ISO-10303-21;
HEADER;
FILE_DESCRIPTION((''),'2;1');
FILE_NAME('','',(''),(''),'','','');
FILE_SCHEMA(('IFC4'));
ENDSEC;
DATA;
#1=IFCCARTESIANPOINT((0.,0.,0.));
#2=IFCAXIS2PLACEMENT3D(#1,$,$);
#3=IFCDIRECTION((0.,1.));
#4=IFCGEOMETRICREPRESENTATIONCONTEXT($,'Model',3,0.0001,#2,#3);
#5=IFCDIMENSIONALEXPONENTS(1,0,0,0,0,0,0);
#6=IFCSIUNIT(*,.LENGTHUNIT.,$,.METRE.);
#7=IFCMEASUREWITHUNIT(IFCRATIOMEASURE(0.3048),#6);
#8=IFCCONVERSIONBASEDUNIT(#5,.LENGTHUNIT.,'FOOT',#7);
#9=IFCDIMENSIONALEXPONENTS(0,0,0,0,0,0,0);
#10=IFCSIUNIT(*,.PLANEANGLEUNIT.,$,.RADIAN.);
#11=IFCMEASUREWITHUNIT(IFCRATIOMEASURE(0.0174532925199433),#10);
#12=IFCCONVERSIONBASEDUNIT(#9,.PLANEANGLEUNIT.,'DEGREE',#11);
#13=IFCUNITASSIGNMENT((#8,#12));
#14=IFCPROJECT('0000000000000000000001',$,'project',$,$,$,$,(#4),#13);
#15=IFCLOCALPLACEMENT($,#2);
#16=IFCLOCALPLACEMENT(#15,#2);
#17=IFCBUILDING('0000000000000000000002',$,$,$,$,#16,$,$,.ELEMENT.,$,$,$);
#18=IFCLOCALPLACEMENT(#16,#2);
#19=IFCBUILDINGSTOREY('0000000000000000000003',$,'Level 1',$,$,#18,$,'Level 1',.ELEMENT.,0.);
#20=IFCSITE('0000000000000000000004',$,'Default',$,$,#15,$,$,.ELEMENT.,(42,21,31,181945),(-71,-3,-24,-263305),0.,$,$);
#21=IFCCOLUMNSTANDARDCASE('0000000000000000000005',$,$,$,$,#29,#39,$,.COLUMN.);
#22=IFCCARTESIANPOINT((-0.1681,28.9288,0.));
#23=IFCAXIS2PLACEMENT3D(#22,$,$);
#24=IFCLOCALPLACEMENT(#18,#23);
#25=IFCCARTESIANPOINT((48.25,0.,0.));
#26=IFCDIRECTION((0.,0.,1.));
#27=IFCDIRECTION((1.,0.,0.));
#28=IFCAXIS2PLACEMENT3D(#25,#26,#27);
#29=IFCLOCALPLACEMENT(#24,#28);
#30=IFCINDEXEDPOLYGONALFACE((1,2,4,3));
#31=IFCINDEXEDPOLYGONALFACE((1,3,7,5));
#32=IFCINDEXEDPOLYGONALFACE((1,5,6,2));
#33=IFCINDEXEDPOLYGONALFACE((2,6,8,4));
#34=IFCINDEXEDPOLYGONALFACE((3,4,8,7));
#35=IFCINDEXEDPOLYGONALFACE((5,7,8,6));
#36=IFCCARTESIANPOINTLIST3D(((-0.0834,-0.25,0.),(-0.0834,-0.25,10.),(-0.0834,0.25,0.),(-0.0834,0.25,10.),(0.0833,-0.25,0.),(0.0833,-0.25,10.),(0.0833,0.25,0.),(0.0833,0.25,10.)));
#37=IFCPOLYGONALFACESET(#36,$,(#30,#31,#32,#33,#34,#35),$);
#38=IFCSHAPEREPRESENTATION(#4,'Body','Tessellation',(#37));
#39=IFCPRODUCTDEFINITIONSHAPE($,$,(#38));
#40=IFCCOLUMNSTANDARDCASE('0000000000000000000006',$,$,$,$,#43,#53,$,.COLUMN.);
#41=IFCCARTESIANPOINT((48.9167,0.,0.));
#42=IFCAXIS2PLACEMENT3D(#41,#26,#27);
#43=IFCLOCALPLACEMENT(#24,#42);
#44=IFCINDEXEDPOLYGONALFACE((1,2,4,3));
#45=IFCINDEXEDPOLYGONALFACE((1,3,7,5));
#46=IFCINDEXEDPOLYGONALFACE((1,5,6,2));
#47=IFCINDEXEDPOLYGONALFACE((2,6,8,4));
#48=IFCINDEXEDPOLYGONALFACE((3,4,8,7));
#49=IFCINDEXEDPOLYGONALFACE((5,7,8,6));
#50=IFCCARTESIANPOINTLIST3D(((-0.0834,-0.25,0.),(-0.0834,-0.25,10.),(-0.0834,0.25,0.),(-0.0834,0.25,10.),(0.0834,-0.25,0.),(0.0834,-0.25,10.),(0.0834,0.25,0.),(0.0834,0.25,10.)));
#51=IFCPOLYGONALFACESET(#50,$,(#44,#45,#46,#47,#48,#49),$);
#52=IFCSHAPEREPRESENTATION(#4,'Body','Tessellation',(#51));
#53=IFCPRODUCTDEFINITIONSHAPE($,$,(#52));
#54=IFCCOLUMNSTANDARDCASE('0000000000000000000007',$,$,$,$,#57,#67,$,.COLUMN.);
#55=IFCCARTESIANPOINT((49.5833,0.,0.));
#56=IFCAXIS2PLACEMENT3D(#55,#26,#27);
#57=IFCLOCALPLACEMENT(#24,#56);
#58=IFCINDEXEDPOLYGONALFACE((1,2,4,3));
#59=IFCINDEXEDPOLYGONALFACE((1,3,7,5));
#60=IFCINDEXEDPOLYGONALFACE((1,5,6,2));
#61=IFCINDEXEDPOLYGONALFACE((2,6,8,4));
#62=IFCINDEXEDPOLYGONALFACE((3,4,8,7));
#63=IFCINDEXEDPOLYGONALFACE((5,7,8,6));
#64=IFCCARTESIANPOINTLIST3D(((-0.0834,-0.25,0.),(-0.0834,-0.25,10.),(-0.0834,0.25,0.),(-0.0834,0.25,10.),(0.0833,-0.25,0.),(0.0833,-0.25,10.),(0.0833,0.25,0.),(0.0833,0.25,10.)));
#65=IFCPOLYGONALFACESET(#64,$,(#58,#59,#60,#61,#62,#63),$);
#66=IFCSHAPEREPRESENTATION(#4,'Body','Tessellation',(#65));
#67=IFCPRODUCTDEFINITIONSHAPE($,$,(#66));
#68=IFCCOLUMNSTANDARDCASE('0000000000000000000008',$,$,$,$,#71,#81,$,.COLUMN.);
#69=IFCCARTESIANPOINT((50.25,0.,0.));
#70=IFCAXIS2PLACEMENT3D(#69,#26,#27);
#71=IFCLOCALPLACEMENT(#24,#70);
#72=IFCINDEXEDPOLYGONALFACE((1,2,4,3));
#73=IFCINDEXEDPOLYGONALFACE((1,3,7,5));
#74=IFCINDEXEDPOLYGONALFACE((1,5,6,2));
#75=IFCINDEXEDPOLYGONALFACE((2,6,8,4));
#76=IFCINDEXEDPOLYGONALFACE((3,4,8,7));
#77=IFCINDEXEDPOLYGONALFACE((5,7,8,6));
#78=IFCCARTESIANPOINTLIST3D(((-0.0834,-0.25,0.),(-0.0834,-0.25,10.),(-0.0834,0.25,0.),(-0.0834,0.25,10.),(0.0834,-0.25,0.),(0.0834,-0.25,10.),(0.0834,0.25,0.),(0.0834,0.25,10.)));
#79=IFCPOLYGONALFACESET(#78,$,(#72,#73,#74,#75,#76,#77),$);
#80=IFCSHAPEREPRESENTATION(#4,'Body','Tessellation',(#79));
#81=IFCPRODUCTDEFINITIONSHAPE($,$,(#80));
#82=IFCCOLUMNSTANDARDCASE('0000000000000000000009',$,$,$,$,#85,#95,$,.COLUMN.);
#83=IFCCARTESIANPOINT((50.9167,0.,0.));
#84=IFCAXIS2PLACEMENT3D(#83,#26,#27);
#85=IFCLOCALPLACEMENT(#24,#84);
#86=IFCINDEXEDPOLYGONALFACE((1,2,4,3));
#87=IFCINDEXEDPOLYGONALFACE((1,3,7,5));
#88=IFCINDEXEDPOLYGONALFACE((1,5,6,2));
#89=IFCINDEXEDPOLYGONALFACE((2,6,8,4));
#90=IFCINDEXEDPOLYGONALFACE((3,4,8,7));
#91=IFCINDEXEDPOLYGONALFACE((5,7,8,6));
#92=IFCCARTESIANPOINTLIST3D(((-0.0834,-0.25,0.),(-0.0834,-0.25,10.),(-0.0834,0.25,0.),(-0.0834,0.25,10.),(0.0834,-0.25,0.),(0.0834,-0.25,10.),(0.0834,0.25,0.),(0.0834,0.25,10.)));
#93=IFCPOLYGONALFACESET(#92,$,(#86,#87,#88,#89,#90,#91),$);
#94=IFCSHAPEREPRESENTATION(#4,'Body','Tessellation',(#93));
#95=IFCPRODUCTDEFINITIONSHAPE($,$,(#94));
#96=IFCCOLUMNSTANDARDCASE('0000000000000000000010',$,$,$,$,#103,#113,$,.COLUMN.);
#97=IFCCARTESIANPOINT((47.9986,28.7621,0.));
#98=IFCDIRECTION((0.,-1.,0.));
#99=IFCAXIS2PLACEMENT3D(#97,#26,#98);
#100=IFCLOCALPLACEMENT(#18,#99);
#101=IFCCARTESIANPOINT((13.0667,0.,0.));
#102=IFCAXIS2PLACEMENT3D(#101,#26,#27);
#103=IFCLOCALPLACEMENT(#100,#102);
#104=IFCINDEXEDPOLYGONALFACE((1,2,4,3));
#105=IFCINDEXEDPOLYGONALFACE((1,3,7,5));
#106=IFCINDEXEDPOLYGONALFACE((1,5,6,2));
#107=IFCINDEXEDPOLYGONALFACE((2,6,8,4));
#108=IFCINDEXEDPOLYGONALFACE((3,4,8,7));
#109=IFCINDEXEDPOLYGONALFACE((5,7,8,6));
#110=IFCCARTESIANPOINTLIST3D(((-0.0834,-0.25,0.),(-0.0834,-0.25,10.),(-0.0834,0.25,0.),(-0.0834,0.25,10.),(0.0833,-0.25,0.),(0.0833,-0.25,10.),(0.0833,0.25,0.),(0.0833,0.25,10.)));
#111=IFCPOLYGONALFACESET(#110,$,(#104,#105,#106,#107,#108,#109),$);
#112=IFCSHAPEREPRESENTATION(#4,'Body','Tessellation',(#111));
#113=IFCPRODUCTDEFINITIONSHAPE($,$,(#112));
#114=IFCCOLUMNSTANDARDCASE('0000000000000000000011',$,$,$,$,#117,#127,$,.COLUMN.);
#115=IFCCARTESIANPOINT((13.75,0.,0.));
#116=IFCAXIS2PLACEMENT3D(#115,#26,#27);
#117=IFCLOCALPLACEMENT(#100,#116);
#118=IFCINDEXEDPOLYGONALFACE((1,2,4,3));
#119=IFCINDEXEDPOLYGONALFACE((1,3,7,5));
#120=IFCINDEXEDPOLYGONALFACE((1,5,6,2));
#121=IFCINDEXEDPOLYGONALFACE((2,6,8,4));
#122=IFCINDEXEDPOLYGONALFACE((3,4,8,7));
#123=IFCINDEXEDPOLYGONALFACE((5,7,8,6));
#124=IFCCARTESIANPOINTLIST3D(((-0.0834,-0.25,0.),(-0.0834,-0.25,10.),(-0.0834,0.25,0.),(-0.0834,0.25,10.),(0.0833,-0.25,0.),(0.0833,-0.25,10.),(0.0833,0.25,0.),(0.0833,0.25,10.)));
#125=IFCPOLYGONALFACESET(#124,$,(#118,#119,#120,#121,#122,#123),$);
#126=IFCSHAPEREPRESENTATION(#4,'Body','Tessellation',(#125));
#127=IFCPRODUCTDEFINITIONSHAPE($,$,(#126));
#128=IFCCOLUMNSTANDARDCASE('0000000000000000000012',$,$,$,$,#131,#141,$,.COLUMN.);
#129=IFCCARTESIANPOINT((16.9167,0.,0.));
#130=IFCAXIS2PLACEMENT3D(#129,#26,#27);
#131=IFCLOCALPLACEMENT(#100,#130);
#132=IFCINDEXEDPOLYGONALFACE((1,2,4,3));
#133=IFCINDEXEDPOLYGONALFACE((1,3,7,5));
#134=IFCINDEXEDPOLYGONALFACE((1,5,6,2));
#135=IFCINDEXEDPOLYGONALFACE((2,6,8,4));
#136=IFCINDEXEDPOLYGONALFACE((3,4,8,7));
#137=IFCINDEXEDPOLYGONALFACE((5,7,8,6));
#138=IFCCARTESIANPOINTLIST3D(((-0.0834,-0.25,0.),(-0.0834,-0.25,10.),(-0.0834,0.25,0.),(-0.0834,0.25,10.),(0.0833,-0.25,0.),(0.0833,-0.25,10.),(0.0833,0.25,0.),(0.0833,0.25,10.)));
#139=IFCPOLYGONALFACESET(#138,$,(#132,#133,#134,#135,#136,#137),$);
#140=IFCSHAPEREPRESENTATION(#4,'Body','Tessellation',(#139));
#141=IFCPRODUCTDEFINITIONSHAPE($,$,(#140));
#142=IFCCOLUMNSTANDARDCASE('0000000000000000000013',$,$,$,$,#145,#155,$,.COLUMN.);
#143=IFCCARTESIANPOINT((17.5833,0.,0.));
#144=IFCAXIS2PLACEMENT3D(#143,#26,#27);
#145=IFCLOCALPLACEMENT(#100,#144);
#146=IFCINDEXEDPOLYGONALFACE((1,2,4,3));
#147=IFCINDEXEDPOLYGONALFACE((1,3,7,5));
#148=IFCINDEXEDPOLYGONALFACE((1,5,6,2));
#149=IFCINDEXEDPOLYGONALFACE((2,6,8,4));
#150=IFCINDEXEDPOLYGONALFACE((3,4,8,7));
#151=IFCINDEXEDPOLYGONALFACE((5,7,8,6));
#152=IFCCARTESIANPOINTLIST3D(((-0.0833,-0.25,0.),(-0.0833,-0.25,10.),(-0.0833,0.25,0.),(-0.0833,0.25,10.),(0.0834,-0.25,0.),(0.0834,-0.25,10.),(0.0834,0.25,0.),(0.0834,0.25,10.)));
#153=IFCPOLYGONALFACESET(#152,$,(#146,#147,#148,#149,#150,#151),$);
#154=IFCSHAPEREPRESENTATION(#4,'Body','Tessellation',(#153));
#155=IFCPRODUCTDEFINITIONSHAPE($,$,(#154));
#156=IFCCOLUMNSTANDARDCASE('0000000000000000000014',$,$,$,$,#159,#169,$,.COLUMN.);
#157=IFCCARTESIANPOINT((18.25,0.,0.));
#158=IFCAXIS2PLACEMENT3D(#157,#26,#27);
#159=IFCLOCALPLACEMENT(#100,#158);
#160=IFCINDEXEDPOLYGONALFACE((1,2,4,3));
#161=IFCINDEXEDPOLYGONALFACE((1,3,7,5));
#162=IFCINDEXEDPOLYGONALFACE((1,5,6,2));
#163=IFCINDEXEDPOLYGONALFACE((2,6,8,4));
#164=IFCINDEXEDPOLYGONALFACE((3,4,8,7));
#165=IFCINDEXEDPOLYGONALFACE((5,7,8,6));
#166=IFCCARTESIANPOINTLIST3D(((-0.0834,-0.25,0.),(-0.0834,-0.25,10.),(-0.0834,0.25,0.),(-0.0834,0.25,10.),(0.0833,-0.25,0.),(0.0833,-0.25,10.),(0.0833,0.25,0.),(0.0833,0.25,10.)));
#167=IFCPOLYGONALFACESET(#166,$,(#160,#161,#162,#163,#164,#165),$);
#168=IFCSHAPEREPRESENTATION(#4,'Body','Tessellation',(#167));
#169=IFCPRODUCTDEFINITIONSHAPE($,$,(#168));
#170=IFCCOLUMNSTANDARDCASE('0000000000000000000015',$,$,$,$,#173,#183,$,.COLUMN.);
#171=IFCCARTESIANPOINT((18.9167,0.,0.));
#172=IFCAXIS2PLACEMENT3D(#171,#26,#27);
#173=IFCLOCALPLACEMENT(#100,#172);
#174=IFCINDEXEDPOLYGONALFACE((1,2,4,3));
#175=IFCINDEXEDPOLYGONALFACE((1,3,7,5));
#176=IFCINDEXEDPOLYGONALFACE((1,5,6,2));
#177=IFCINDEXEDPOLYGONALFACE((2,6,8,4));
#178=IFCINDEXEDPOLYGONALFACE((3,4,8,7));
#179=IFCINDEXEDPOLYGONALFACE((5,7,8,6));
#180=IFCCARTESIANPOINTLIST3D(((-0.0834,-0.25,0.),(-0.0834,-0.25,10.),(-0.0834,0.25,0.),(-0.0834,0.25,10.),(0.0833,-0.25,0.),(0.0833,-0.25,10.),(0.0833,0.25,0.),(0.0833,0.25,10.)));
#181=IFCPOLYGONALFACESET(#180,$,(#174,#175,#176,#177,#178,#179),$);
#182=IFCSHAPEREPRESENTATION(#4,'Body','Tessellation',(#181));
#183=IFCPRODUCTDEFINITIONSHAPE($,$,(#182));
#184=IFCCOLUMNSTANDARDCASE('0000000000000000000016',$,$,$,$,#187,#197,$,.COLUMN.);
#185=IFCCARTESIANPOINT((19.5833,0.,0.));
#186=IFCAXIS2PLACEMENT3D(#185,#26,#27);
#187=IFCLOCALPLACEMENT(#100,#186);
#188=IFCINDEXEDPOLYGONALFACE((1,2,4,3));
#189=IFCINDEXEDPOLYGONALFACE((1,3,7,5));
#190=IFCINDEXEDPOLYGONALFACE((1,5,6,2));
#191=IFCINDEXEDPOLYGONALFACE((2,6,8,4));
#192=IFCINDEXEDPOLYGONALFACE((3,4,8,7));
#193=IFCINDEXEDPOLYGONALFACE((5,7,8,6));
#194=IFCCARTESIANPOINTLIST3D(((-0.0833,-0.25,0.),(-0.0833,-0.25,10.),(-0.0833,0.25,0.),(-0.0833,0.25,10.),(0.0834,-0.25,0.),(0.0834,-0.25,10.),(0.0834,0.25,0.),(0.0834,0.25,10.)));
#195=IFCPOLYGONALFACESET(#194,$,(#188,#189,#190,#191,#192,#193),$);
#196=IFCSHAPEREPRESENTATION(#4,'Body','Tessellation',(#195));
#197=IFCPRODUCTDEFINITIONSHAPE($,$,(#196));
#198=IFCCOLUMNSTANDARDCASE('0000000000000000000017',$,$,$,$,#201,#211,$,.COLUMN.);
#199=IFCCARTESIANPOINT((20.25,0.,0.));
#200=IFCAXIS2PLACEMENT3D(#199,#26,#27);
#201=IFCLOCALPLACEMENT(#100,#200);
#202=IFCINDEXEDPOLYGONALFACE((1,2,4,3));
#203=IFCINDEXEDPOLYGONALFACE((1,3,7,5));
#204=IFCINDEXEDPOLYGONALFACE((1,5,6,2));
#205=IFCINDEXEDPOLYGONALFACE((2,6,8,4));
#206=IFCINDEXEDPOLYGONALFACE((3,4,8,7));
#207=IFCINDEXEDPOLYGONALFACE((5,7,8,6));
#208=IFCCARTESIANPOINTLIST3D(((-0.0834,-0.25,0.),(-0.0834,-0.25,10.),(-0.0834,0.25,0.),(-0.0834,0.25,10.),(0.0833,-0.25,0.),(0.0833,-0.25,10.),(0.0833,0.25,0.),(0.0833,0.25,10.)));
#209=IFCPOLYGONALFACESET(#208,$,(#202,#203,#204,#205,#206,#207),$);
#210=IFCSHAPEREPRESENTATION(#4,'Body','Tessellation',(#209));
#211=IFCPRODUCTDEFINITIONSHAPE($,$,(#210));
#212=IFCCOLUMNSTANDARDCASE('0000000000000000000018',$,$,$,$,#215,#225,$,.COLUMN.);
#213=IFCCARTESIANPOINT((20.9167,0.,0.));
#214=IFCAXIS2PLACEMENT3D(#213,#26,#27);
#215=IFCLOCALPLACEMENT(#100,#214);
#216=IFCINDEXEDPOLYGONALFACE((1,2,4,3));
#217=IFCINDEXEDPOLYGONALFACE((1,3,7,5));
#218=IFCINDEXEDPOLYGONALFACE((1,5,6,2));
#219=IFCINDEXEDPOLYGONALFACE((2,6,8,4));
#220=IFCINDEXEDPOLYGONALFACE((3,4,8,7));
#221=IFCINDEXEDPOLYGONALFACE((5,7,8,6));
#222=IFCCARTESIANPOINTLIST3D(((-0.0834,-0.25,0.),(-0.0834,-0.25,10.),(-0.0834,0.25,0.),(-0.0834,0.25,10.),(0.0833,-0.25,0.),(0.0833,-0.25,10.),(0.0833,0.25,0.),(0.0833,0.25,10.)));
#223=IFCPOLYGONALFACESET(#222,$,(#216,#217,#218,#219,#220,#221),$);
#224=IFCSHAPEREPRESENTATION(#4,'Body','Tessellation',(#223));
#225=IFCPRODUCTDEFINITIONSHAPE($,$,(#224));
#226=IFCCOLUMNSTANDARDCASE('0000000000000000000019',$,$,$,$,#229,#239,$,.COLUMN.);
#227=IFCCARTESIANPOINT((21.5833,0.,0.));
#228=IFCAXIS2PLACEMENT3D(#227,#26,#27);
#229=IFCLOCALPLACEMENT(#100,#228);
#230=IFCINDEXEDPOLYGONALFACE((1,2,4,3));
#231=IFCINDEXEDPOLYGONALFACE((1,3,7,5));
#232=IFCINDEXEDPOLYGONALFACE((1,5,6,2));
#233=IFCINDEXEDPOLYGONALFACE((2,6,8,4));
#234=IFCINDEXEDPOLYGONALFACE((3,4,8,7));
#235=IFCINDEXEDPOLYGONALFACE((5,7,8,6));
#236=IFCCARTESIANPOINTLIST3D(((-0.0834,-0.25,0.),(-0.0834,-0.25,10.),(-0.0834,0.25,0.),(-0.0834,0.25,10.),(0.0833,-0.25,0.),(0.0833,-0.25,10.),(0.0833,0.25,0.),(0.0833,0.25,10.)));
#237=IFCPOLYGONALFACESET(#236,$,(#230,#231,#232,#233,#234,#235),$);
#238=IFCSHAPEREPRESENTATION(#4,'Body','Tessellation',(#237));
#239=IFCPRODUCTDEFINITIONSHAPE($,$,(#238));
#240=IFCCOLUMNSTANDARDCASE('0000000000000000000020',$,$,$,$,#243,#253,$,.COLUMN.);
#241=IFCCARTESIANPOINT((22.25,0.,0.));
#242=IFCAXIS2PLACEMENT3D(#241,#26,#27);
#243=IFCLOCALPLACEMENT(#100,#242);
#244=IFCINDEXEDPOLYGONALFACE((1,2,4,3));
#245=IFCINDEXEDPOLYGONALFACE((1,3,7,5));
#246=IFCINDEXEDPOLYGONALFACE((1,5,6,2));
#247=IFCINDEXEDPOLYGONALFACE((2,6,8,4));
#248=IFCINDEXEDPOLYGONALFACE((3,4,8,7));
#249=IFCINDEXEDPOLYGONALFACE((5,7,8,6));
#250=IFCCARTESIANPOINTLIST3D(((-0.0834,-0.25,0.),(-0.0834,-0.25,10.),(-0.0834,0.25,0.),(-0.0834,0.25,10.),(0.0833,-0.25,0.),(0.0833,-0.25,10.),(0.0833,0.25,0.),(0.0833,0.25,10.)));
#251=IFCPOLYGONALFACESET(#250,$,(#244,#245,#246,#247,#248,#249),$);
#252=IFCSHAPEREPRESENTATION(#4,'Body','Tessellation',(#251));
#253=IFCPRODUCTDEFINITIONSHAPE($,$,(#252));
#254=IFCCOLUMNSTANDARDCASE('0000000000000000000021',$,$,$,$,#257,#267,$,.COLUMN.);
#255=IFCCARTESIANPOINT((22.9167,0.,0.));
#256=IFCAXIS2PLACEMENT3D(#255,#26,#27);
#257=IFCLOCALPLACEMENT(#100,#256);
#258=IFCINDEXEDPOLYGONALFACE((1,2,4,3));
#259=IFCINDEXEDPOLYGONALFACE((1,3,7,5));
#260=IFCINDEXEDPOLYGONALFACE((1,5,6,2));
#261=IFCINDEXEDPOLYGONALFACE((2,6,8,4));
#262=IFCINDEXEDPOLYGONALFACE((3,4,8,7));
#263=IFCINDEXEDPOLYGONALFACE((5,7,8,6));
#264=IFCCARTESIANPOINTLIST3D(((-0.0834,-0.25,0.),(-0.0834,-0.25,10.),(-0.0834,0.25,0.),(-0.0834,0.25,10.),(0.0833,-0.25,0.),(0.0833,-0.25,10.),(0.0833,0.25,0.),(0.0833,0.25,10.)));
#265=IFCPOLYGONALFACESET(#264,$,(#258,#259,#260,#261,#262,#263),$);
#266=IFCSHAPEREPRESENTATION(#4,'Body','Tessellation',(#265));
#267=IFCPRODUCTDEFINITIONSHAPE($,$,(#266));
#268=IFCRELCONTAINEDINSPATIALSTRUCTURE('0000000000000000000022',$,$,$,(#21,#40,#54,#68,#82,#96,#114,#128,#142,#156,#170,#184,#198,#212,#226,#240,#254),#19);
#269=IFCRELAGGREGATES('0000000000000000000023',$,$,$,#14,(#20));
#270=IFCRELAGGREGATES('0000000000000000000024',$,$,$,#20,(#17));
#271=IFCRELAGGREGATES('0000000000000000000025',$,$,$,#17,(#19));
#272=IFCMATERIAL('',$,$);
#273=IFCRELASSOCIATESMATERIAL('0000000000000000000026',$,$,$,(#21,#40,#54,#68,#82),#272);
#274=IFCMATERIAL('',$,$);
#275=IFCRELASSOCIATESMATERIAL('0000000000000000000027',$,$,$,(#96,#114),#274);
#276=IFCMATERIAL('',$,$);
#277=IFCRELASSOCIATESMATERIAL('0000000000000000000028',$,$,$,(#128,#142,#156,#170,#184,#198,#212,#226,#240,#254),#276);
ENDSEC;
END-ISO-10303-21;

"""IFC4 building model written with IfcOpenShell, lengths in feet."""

from ifc_helpers import new_model, entity, si_unit, converted_unit, direction, frame, origin, place, context, project, spatial, rectangle, extrude, material, element, save


model = new_model("IFC4")

# Units and contexts
model_context = context("Model", 3, precision=0.0001, world=origin(), true_north=direction((0.0, 1.0)))
ifc_project = project(units=[converted_unit("LENGTHUNIT", "FOOT", entity("IfcRatioMeasure", 0.3048), si_unit("LENGTHUNIT", "METRE"), dimensions=[1, 0, 0, 0, 0, 0, 0]), converted_unit("PLANEANGLEUNIT", "DEGREE", entity("IfcRatioMeasure", 0.0174532925199433), si_unit("PLANEANGLEUNIT", "RADIAN"), dimensions=[0, 0, 0, 0, 0, 0, 0])], contexts=[model_context])

# Site, building, storey
site_placement = place(None, origin())
site = spatial("IfcSite", under=ifc_project, at=site_placement, Name="Default", CompositionType="ELEMENT", RefLatitude=(42, 21, 31, 181945), RefLongitude=(-71, -3, -24, -263305), RefElevation=0.0)
building_placement = place(site_placement, origin())
building = spatial("IfcBuilding", under=site, at=building_placement, CompositionType="ELEMENT")
storey_placement = place(building_placement, origin())
storey = spatial("IfcBuildingStorey", under=building, at=storey_placement, Name="Level 1", LongName="Level 1", CompositionType="ELEMENT", Elevation=0.0)

# Columns
ifc_material_1 = material(Name="")
placement_1 = place(storey_placement, frame((-0.1681, 28.9288, 0.0)))
for number, where, z_axis, x_axis in (
    (1, (48.25, 0.0, 0.0), (0.0, 0.0, 1.0), (1.0, 0.0, 0.0)),
    (2, (48.9167, 0.0, 0.0), (0.0, 0.0, 1.0), (1.0, 0.0, 0.0)),
    (3, (49.5833, 0.0, 0.0), (0.0, 0.0, 1.0), (1.0, 0.0, 0.0)),
    (4, (50.25, 0.0, 0.0), (0.0, 0.0, 1.0), (1.0, 0.0, 0.0)),
    (5, (50.9167, 0.0, 0.0), (0.0, 0.0, 1.0), (1.0, 0.0, 0.0)),
):
    element("IfcColumnStandardCase", number, at=place(placement_1, frame(where, z_axis=z_axis, x_axis=x_axis)), inside=storey, material=ifc_material_1, PredefinedType="COLUMN", context=model_context, shape_type="SweptSolid", body=[
        extrude(rectangle(XDim=0.1667, YDim=0.5), origin(), (0.0, 0.0, 1.0), 10.0),
    ])
ifc_material_2 = material(Name="")
placement_2 = place(storey_placement, frame((47.9986, 28.7621, 0.0), z_axis=(0.0, 0.0, 1.0), x_axis=(0.0, -1.0, 0.0)))
for number, where, z_axis, x_axis in (
    (6, (13.0667, 0.0, 0.0), (0.0, 0.0, 1.0), (1.0, 0.0, 0.0)),
    (7, (13.75, 0.0, 0.0), (0.0, 0.0, 1.0), (1.0, 0.0, 0.0)),
):
    element("IfcColumnStandardCase", number, at=place(placement_2, frame(where, z_axis=z_axis, x_axis=x_axis)), inside=storey, material=ifc_material_2, PredefinedType="COLUMN", context=model_context, shape_type="SweptSolid", body=[
        extrude(rectangle(XDim=0.1667, YDim=0.5), origin(), (0.0, 0.0, 1.0), 10.0),
    ])
ifc_material_3 = material(Name="")
for number, where, z_axis, x_axis in (
    (8, (16.9167, 0.0, 0.0), (0.0, 0.0, 1.0), (1.0, 0.0, 0.0)),
    (9, (17.5833, 0.0, 0.0), (0.0, 0.0, 1.0), (1.0, 0.0, 0.0)),
    (10, (18.25, 0.0, 0.0), (0.0, 0.0, 1.0), (1.0, 0.0, 0.0)),
    (11, (18.9167, 0.0, 0.0), (0.0, 0.0, 1.0), (1.0, 0.0, 0.0)),
    (12, (19.5833, 0.0, 0.0), (0.0, 0.0, 1.0), (1.0, 0.0, 0.0)),
    (13, (20.25, 0.0, 0.0), (0.0, 0.0, 1.0), (1.0, 0.0, 0.0)),
    (14, (20.9167, 0.0, 0.0), (0.0, 0.0, 1.0), (1.0, 0.0, 0.0)),
    (15, (21.5833, 0.0, 0.0), (0.0, 0.0, 1.0), (1.0, 0.0, 0.0)),
    (16, (22.25, 0.0, 0.0), (0.0, 0.0, 1.0), (1.0, 0.0, 0.0)),
    (17, (22.9167, 0.0, 0.0), (0.0, 0.0, 1.0), (1.0, 0.0, 0.0)),
):
    element("IfcColumnStandardCase", number, at=place(placement_2, frame(where, z_axis=z_axis, x_axis=x_axis)), inside=storey, material=ifc_material_3, PredefinedType="COLUMN", context=model_context, shape_type="SweptSolid", body=[
        extrude(rectangle(XDim=0.1667, YDim=0.5), origin(), (0.0, 0.0, 1.0), 10.0),
    ])

save(model, "model.ifc")
